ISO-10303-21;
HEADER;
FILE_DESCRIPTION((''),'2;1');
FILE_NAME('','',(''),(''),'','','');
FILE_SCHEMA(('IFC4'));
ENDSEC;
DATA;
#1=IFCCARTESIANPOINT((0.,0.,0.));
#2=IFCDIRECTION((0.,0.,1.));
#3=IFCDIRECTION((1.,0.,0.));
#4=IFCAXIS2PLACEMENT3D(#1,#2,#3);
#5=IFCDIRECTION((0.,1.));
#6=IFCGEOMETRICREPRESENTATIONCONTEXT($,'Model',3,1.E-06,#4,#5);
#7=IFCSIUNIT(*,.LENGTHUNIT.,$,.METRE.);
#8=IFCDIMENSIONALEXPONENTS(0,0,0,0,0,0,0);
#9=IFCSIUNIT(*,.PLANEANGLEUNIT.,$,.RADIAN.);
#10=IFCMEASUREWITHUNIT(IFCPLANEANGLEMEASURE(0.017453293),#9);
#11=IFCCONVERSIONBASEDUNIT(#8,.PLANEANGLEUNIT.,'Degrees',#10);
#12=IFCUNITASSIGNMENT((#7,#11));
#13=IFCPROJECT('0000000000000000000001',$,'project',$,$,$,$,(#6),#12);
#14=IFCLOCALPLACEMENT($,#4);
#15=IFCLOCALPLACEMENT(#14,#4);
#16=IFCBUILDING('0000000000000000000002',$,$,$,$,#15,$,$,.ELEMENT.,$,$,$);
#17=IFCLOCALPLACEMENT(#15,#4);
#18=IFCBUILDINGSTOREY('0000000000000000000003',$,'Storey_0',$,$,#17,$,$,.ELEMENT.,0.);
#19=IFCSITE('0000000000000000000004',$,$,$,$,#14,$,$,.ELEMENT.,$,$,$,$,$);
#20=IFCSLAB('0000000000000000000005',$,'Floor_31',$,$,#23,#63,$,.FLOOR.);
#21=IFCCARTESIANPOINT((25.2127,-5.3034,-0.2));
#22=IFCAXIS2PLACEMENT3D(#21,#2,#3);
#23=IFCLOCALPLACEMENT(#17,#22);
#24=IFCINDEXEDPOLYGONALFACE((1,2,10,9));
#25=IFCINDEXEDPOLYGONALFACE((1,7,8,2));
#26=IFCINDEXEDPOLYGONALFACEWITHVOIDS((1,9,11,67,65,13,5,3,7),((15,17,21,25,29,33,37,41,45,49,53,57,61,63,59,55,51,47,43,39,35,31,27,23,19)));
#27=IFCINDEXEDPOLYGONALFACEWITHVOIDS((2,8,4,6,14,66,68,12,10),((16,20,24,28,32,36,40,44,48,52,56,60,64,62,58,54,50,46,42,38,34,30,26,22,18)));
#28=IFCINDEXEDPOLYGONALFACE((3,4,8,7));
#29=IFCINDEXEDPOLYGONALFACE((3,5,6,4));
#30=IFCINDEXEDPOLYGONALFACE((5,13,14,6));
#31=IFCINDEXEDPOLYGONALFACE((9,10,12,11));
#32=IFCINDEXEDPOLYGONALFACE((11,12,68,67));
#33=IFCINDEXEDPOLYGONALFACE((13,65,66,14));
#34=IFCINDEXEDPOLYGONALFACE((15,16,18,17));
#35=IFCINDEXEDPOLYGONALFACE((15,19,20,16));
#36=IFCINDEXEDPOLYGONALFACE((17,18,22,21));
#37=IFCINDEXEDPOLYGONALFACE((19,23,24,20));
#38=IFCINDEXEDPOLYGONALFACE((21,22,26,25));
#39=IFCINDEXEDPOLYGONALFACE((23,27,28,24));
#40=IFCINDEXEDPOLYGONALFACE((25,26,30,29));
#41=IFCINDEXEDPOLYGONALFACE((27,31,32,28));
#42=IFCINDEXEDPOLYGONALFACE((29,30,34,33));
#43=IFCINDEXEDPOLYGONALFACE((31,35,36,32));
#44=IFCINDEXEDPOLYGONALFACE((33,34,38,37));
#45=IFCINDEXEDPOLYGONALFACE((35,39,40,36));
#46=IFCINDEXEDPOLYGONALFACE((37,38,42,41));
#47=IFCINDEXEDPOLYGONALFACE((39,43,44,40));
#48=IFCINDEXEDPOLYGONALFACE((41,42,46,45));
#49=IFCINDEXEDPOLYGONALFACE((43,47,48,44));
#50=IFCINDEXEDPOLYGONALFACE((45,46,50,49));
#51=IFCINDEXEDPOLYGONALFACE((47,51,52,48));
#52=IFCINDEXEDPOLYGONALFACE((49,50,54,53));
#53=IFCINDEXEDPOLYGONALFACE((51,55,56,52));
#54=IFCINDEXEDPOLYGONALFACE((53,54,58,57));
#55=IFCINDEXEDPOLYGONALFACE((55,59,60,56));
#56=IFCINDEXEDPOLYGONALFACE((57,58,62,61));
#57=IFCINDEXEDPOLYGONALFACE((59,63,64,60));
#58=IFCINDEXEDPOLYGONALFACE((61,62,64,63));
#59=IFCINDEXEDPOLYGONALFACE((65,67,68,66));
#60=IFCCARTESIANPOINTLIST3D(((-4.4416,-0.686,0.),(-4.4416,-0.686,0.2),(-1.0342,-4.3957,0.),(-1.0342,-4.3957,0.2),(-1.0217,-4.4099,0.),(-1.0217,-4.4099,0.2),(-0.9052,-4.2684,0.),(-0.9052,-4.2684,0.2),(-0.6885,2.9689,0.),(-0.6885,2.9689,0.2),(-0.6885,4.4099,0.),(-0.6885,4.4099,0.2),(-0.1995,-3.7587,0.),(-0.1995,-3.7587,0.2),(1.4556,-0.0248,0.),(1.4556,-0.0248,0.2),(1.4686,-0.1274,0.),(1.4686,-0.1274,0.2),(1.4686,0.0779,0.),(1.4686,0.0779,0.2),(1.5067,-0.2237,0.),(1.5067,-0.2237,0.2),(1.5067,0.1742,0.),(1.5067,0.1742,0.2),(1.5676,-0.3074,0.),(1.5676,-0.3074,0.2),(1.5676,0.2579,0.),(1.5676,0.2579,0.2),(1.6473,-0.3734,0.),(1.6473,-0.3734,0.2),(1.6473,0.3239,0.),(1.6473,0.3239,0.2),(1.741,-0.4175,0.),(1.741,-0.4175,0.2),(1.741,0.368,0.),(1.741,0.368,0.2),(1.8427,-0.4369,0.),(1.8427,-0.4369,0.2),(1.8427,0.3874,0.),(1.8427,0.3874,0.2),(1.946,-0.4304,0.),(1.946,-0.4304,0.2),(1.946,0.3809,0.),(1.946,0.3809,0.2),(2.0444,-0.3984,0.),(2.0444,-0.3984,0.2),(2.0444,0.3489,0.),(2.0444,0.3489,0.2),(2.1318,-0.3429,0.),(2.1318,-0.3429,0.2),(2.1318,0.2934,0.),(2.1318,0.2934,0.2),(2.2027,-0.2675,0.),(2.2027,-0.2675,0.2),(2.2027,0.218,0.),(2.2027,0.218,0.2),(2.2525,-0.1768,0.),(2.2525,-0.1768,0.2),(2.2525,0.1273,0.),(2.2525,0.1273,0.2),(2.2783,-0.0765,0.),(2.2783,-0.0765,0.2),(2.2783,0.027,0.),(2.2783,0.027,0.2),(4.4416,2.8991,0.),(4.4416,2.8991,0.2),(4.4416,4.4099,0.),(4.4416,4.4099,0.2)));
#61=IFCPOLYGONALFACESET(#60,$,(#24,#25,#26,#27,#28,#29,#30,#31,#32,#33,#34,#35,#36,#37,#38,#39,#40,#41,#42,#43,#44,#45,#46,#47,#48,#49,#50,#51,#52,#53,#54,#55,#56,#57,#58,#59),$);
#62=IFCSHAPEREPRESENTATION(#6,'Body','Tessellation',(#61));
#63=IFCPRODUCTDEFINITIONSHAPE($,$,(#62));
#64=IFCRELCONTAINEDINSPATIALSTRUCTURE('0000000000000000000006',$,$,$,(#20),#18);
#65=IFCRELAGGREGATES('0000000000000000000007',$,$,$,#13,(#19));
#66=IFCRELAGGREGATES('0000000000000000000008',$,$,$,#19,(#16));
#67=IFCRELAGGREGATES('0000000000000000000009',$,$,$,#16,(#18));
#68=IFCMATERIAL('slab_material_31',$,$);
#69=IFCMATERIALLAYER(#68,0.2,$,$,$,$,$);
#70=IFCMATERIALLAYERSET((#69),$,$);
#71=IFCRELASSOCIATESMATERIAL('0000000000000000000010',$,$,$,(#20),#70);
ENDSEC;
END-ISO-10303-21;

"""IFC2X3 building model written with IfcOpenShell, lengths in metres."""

from ifc_helpers import new_model, entity, si_unit, converted_unit, direction, frame, origin_with_axes, place, context, project, spatial, polyline, outline, extrude, material, layer, layer_set, layer_usage, element, save


model = new_model("IFC2X3")

# Units and contexts
model_context = context("Model", 3, precision=1e-06, world=origin_with_axes(), true_north=direction((0.0, 1.0)))
ifc_project = project(units=[si_unit("LENGTHUNIT", "METRE"), converted_unit("PLANEANGLEUNIT", "Degrees", entity("IfcPlaneAngleMeasure", 0.017453293), si_unit("PLANEANGLEUNIT", "RADIAN"), dimensions=[0, 0, 0, 0, 0, 0, 0])], contexts=[model_context])

# Site, building, storey
site_placement = place(None, origin_with_axes())
site = spatial("IfcSite", under=ifc_project, at=site_placement, CompositionType="ELEMENT")
building_placement = place(site_placement, origin_with_axes())
building = spatial("IfcBuilding", under=site, at=building_placement, CompositionType="ELEMENT")
storey_placement = place(building_placement, origin_with_axes())
storey = spatial("IfcBuildingStorey", under=building, at=storey_placement, Name="Storey_0", CompositionType="ELEMENT", Elevation=0.0)

# Slab, opening
ifc_material_1 = material(Name="slab_material_31")
ifc_layer_1 = layer(ifc_material_1, 0.2)
ifc_layer_set_1 = layer_set([ifc_layer_1])
ifc_layer_usage_1 = layer_usage(ifc_layer_set_1, "AXIS3", "POSITIVE", 0.0)
slab_placement = place(storey_placement, frame((25.2127, -5.3034, -0.2), z_axis=(0.0, 0.0, 1.0), x_axis=(1.0, 0.0, 0.0)))
slab = element("IfcSlab", 1, at=slab_placement, inside=storey, material=ifc_layer_usage_1, Name="Floor_31", PredefinedType="FLOOR", context=model_context, shape_type="SweptSolid", body=[
    extrude(outline(polyline([(4.4416, 2.8991), (-0.1995, -3.7587), (-1.0217, -4.4099), (-1.0342, -4.3957), (-0.9052, -4.2683), (-4.4416, -0.686), (-0.6885, 2.9689), (-0.6885, 4.4099), (4.4416, 4.4099), (4.4416, 2.8991)])), origin_with_axes(), (0.0, 0.0, 1.0), 0.2),
])
opening_1_placement = place(slab_placement, origin_with_axes())
element("IfcOpeningElement", 2, at=opening_1_placement, cuts=slab, context=model_context, shape_type="SweptSolid", body=[
    extrude(outline(polyline([(1.8427, 0.3774), (1.741, 0.358), (1.6473, 0.3139), (1.5676, 0.2479), (1.5067, 0.1642), (1.4686, 0.0679), (1.4556, -0.0348), (1.4686, -0.1374), (1.5067, -0.2337), (1.5676, -0.3174), (1.6473, -0.3834), (1.741, -0.4275), (1.8427, -0.4469), (1.946, -0.4404), (2.0444, -0.4084), (2.1318, -0.3529), (2.2027, -0.2775), (2.2525, -0.1868), (2.2783, -0.0865), (2.2783, 0.017), (2.2525, 0.1173), (2.2027, 0.208), (2.1318, 0.2834), (2.0444, 0.3389), (1.946, 0.3709), (1.8427, 0.3774)])), frame((0.0, 0.01, 0.0), z_axis=(0.0, 0.0, 1.0), x_axis=(1.0, 0.0, 0.0)), (0.0, 0.0, 1.0), 0.22),
])

save(model, "model.ifc")
